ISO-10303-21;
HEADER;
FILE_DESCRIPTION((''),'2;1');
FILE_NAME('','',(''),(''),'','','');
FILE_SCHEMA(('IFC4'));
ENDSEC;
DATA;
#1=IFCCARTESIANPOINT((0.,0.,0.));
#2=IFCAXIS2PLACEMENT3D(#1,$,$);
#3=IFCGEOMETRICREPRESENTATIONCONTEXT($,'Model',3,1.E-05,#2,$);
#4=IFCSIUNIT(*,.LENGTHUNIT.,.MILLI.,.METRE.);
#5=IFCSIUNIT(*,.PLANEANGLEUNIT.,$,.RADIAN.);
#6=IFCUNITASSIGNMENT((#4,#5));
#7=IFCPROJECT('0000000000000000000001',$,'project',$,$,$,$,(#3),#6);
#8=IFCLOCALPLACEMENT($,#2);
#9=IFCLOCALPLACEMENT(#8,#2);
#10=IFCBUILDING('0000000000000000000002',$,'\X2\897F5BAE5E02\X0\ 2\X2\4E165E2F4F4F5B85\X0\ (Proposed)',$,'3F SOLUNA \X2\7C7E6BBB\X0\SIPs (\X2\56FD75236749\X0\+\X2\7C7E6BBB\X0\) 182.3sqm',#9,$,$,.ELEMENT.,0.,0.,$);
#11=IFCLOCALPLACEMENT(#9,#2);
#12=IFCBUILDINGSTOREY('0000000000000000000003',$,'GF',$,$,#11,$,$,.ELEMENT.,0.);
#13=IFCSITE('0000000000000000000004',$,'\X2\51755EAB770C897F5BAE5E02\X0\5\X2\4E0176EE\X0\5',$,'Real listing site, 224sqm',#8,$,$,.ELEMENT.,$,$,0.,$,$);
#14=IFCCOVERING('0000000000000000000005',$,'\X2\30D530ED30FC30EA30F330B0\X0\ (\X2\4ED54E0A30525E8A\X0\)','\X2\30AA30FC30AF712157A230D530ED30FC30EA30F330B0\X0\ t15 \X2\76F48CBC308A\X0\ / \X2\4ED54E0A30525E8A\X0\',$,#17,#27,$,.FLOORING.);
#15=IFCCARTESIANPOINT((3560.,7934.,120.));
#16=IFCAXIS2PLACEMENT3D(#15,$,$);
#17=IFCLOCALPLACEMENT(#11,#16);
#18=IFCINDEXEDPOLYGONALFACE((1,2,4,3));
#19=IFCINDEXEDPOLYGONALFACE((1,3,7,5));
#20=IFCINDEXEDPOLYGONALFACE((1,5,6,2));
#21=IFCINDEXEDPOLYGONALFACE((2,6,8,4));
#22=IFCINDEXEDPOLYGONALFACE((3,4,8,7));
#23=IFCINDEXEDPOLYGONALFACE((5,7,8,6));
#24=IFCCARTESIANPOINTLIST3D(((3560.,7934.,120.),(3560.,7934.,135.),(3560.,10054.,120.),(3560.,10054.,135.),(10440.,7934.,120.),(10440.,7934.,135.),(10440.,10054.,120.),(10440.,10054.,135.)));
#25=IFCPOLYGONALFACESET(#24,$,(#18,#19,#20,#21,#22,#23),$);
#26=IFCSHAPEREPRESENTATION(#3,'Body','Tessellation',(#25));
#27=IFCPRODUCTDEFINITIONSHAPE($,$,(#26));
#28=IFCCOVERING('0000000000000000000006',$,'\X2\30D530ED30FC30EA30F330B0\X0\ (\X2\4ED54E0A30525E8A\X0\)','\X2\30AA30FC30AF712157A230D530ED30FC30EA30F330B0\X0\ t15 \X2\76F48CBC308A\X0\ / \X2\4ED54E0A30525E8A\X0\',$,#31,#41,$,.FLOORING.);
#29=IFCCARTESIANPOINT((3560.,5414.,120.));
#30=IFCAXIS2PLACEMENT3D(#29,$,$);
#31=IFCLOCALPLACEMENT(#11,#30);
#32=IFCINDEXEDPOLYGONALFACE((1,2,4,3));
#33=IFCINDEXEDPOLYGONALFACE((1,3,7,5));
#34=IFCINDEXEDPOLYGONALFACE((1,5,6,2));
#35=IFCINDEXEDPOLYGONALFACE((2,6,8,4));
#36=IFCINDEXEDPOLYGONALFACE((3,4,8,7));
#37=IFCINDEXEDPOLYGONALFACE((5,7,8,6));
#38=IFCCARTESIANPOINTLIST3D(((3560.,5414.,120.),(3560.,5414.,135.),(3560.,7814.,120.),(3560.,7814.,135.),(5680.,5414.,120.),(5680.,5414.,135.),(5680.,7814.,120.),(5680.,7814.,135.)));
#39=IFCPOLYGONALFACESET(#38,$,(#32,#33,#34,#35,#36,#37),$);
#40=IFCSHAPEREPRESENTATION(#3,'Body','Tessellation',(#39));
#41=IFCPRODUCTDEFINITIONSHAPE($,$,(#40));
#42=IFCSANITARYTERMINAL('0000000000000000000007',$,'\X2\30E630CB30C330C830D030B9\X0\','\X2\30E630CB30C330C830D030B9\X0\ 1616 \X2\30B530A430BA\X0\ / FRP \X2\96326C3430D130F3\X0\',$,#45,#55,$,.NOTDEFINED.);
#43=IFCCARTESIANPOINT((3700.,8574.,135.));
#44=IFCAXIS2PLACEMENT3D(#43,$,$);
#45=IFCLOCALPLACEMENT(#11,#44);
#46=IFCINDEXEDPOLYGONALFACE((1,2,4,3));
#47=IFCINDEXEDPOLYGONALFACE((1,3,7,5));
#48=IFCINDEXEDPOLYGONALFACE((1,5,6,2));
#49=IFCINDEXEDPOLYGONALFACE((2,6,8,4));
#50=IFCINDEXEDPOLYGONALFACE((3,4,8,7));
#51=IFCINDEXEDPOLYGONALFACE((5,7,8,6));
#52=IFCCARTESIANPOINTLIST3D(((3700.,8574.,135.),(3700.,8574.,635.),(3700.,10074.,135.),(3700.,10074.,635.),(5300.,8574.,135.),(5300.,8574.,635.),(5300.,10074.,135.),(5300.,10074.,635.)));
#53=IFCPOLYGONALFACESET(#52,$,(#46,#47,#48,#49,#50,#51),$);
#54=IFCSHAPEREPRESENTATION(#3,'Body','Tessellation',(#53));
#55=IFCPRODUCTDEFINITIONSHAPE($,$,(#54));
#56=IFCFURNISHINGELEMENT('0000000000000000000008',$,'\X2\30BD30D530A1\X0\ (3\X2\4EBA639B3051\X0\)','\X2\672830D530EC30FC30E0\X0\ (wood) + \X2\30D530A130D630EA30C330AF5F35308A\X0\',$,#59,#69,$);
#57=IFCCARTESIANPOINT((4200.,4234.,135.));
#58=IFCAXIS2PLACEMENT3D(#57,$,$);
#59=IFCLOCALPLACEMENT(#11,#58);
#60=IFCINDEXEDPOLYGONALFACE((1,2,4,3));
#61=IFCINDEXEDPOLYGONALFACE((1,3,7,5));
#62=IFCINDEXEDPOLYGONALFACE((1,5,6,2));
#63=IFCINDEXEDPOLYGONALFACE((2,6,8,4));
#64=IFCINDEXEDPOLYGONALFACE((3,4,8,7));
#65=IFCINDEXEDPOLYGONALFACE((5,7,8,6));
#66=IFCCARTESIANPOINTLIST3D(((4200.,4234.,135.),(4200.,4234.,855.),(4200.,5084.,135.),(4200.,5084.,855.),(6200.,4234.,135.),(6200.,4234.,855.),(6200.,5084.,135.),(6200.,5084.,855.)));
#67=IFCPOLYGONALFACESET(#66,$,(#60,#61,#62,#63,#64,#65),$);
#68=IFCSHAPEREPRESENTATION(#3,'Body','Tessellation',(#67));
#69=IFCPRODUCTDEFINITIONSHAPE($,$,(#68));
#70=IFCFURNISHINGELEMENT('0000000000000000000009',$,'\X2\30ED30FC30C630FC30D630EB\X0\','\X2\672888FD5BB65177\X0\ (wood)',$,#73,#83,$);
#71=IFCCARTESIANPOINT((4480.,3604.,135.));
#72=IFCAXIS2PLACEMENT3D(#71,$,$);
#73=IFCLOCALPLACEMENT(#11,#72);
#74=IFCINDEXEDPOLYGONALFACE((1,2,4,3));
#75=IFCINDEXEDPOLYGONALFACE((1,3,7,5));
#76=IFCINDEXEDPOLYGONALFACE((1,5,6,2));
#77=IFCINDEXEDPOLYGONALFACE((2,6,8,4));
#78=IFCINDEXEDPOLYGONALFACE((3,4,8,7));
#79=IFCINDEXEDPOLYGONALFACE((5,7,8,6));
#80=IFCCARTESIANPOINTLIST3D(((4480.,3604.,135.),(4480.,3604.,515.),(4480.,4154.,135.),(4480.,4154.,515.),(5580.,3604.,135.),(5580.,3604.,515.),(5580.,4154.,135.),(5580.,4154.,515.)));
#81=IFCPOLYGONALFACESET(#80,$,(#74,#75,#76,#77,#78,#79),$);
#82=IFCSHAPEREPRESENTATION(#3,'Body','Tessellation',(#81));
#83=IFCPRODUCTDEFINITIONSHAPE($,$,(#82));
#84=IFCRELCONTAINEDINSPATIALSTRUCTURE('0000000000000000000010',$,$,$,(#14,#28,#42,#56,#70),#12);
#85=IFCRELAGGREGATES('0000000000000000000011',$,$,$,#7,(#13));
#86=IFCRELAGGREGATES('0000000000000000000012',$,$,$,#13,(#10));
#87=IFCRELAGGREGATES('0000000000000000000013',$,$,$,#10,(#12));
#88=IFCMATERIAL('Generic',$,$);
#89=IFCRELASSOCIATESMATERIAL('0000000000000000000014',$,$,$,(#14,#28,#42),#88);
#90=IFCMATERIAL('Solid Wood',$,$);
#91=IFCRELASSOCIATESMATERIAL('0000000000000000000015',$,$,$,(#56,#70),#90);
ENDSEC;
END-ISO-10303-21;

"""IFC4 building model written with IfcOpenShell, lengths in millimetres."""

from ifc_helpers import new_model, si_unit, frame, frame_2d, origin, place, context, project, spatial, rectangle, extrude, material, element, save


model = new_model("IFC4")

# Units and contexts
model_context = context("Model", 3, precision=1e-05, world=origin())
ifc_project = project(units=[si_unit("LENGTHUNIT", "METRE", prefix="MILLI"), si_unit("PLANEANGLEUNIT", "RADIAN")], contexts=[model_context])

# Site, building, storey
site_placement = place(None, origin())
site = spatial("IfcSite", under=ifc_project, at=site_placement, Name="兵庫県西宮市5丁目5", ObjectType="Real listing site, 224sqm", CompositionType="ELEMENT", RefElevation=0.0)
building_placement = place(site_placement, origin())
building = spatial("IfcBuilding", under=site, at=building_placement, Name="西宮市 2世帯住宅 (Proposed)", ObjectType="3F SOLUNA 籾殻SIPs (国産杉+籾殻) 182.3sqm", CompositionType="ELEMENT", ElevationOfRefHeight=0.0, ElevationOfTerrain=0.0)
storey_placement = place(building_placement, origin())
storey = spatial("IfcBuildingStorey", under=building, at=storey_placement, Name="GF", CompositionType="ELEMENT", Elevation=0.0)

# Shared definitions
ifc_material_1 = material(Name="Solid Wood")

# Coverings
ifc_material_2 = material(Name="Generic")
covering_1_placement = place(storey_placement, frame((3560.0, 7934.0, 120.0)))
element("IfcCovering", 1, at=covering_1_placement, inside=storey, material=ifc_material_2, Name="フローリング (仕上げ床)", Description="オーク無垢フローリング t15 直貼り / 仕上げ床", PredefinedType="FLOORING", context=model_context, shape_type="SweptSolid", body=[
    extrude(rectangle(XDim=6880.0, YDim=2120.0, at=frame_2d((3440.0, 1060.0))), frame((3560.0, 7934.0, 120.0)), (0.0, 0.0, 1.0), 15.0),
])
covering_2_placement = place(storey_placement, frame((3560.0, 5414.0, 120.0)))
element("IfcCovering", 2, at=covering_2_placement, inside=storey, material=ifc_material_2, Name="フローリング (仕上げ床)", Description="オーク無垢フローリング t15 直貼り / 仕上げ床", PredefinedType="FLOORING", context=model_context, shape_type="SweptSolid", body=[
    extrude(rectangle(XDim=2120.0, YDim=2400.0, at=frame_2d((1060.0, 1200.0))), frame((3560.0, 5414.0, 120.0)), (0.0, 0.0, 1.0), 15.0),
])

# Sanitary terminal
sanitary_terminal_placement = place(storey_placement, frame((3700.0, 8574.0, 135.0)))
element("IfcSanitaryTerminal", 3, at=sanitary_terminal_placement, inside=storey, material=ifc_material_2, Name="ユニットバス", Description="ユニットバス 1616 サイズ / FRP 防水パン", PredefinedType="NOTDEFINED", context=model_context, shape_type="SweptSolid", body=[
    extrude(rectangle(XDim=1600.0, YDim=1500.0, at=frame_2d((800.0, 750.0))), frame((3700.0, 8574.0, 135.0)), (0.0, 0.0, 1.0), 500.0),
])

# Furnishing elements
furnishing_1_placement = place(storey_placement, frame((4200.0, 4234.0, 135.0)))
element("IfcFurnishingElement", 4, at=furnishing_1_placement, inside=storey, material=ifc_material_1, Name="ソファ (3人掛け)", Description="木フレーム (wood) + ファブリック張り", context=model_context, shape_type="SweptSolid", body=[
    extrude(rectangle(XDim=2000.0, YDim=850.0, at=frame_2d((1000.0, 425.0))), frame((4200.0, 4234.0, 135.0)), (0.0, 0.0, 1.0), 720.0),
])
furnishing_2_placement = place(storey_placement, frame((4480.0, 3604.0, 135.0)))
element("IfcFurnishingElement", 5, at=furnishing_2_placement, inside=storey, material=ifc_material_1, Name="ローテーブル", Description="木製家具 (wood)", context=model_context, shape_type="SweptSolid", body=[
    extrude(rectangle(XDim=1100.0, YDim=550.0, at=frame_2d((550.0, 275.0))), frame((4480.0, 3604.0, 135.0)), (0.0, 0.0, 1.0), 380.0),
])

save(model, "model.ifc")
